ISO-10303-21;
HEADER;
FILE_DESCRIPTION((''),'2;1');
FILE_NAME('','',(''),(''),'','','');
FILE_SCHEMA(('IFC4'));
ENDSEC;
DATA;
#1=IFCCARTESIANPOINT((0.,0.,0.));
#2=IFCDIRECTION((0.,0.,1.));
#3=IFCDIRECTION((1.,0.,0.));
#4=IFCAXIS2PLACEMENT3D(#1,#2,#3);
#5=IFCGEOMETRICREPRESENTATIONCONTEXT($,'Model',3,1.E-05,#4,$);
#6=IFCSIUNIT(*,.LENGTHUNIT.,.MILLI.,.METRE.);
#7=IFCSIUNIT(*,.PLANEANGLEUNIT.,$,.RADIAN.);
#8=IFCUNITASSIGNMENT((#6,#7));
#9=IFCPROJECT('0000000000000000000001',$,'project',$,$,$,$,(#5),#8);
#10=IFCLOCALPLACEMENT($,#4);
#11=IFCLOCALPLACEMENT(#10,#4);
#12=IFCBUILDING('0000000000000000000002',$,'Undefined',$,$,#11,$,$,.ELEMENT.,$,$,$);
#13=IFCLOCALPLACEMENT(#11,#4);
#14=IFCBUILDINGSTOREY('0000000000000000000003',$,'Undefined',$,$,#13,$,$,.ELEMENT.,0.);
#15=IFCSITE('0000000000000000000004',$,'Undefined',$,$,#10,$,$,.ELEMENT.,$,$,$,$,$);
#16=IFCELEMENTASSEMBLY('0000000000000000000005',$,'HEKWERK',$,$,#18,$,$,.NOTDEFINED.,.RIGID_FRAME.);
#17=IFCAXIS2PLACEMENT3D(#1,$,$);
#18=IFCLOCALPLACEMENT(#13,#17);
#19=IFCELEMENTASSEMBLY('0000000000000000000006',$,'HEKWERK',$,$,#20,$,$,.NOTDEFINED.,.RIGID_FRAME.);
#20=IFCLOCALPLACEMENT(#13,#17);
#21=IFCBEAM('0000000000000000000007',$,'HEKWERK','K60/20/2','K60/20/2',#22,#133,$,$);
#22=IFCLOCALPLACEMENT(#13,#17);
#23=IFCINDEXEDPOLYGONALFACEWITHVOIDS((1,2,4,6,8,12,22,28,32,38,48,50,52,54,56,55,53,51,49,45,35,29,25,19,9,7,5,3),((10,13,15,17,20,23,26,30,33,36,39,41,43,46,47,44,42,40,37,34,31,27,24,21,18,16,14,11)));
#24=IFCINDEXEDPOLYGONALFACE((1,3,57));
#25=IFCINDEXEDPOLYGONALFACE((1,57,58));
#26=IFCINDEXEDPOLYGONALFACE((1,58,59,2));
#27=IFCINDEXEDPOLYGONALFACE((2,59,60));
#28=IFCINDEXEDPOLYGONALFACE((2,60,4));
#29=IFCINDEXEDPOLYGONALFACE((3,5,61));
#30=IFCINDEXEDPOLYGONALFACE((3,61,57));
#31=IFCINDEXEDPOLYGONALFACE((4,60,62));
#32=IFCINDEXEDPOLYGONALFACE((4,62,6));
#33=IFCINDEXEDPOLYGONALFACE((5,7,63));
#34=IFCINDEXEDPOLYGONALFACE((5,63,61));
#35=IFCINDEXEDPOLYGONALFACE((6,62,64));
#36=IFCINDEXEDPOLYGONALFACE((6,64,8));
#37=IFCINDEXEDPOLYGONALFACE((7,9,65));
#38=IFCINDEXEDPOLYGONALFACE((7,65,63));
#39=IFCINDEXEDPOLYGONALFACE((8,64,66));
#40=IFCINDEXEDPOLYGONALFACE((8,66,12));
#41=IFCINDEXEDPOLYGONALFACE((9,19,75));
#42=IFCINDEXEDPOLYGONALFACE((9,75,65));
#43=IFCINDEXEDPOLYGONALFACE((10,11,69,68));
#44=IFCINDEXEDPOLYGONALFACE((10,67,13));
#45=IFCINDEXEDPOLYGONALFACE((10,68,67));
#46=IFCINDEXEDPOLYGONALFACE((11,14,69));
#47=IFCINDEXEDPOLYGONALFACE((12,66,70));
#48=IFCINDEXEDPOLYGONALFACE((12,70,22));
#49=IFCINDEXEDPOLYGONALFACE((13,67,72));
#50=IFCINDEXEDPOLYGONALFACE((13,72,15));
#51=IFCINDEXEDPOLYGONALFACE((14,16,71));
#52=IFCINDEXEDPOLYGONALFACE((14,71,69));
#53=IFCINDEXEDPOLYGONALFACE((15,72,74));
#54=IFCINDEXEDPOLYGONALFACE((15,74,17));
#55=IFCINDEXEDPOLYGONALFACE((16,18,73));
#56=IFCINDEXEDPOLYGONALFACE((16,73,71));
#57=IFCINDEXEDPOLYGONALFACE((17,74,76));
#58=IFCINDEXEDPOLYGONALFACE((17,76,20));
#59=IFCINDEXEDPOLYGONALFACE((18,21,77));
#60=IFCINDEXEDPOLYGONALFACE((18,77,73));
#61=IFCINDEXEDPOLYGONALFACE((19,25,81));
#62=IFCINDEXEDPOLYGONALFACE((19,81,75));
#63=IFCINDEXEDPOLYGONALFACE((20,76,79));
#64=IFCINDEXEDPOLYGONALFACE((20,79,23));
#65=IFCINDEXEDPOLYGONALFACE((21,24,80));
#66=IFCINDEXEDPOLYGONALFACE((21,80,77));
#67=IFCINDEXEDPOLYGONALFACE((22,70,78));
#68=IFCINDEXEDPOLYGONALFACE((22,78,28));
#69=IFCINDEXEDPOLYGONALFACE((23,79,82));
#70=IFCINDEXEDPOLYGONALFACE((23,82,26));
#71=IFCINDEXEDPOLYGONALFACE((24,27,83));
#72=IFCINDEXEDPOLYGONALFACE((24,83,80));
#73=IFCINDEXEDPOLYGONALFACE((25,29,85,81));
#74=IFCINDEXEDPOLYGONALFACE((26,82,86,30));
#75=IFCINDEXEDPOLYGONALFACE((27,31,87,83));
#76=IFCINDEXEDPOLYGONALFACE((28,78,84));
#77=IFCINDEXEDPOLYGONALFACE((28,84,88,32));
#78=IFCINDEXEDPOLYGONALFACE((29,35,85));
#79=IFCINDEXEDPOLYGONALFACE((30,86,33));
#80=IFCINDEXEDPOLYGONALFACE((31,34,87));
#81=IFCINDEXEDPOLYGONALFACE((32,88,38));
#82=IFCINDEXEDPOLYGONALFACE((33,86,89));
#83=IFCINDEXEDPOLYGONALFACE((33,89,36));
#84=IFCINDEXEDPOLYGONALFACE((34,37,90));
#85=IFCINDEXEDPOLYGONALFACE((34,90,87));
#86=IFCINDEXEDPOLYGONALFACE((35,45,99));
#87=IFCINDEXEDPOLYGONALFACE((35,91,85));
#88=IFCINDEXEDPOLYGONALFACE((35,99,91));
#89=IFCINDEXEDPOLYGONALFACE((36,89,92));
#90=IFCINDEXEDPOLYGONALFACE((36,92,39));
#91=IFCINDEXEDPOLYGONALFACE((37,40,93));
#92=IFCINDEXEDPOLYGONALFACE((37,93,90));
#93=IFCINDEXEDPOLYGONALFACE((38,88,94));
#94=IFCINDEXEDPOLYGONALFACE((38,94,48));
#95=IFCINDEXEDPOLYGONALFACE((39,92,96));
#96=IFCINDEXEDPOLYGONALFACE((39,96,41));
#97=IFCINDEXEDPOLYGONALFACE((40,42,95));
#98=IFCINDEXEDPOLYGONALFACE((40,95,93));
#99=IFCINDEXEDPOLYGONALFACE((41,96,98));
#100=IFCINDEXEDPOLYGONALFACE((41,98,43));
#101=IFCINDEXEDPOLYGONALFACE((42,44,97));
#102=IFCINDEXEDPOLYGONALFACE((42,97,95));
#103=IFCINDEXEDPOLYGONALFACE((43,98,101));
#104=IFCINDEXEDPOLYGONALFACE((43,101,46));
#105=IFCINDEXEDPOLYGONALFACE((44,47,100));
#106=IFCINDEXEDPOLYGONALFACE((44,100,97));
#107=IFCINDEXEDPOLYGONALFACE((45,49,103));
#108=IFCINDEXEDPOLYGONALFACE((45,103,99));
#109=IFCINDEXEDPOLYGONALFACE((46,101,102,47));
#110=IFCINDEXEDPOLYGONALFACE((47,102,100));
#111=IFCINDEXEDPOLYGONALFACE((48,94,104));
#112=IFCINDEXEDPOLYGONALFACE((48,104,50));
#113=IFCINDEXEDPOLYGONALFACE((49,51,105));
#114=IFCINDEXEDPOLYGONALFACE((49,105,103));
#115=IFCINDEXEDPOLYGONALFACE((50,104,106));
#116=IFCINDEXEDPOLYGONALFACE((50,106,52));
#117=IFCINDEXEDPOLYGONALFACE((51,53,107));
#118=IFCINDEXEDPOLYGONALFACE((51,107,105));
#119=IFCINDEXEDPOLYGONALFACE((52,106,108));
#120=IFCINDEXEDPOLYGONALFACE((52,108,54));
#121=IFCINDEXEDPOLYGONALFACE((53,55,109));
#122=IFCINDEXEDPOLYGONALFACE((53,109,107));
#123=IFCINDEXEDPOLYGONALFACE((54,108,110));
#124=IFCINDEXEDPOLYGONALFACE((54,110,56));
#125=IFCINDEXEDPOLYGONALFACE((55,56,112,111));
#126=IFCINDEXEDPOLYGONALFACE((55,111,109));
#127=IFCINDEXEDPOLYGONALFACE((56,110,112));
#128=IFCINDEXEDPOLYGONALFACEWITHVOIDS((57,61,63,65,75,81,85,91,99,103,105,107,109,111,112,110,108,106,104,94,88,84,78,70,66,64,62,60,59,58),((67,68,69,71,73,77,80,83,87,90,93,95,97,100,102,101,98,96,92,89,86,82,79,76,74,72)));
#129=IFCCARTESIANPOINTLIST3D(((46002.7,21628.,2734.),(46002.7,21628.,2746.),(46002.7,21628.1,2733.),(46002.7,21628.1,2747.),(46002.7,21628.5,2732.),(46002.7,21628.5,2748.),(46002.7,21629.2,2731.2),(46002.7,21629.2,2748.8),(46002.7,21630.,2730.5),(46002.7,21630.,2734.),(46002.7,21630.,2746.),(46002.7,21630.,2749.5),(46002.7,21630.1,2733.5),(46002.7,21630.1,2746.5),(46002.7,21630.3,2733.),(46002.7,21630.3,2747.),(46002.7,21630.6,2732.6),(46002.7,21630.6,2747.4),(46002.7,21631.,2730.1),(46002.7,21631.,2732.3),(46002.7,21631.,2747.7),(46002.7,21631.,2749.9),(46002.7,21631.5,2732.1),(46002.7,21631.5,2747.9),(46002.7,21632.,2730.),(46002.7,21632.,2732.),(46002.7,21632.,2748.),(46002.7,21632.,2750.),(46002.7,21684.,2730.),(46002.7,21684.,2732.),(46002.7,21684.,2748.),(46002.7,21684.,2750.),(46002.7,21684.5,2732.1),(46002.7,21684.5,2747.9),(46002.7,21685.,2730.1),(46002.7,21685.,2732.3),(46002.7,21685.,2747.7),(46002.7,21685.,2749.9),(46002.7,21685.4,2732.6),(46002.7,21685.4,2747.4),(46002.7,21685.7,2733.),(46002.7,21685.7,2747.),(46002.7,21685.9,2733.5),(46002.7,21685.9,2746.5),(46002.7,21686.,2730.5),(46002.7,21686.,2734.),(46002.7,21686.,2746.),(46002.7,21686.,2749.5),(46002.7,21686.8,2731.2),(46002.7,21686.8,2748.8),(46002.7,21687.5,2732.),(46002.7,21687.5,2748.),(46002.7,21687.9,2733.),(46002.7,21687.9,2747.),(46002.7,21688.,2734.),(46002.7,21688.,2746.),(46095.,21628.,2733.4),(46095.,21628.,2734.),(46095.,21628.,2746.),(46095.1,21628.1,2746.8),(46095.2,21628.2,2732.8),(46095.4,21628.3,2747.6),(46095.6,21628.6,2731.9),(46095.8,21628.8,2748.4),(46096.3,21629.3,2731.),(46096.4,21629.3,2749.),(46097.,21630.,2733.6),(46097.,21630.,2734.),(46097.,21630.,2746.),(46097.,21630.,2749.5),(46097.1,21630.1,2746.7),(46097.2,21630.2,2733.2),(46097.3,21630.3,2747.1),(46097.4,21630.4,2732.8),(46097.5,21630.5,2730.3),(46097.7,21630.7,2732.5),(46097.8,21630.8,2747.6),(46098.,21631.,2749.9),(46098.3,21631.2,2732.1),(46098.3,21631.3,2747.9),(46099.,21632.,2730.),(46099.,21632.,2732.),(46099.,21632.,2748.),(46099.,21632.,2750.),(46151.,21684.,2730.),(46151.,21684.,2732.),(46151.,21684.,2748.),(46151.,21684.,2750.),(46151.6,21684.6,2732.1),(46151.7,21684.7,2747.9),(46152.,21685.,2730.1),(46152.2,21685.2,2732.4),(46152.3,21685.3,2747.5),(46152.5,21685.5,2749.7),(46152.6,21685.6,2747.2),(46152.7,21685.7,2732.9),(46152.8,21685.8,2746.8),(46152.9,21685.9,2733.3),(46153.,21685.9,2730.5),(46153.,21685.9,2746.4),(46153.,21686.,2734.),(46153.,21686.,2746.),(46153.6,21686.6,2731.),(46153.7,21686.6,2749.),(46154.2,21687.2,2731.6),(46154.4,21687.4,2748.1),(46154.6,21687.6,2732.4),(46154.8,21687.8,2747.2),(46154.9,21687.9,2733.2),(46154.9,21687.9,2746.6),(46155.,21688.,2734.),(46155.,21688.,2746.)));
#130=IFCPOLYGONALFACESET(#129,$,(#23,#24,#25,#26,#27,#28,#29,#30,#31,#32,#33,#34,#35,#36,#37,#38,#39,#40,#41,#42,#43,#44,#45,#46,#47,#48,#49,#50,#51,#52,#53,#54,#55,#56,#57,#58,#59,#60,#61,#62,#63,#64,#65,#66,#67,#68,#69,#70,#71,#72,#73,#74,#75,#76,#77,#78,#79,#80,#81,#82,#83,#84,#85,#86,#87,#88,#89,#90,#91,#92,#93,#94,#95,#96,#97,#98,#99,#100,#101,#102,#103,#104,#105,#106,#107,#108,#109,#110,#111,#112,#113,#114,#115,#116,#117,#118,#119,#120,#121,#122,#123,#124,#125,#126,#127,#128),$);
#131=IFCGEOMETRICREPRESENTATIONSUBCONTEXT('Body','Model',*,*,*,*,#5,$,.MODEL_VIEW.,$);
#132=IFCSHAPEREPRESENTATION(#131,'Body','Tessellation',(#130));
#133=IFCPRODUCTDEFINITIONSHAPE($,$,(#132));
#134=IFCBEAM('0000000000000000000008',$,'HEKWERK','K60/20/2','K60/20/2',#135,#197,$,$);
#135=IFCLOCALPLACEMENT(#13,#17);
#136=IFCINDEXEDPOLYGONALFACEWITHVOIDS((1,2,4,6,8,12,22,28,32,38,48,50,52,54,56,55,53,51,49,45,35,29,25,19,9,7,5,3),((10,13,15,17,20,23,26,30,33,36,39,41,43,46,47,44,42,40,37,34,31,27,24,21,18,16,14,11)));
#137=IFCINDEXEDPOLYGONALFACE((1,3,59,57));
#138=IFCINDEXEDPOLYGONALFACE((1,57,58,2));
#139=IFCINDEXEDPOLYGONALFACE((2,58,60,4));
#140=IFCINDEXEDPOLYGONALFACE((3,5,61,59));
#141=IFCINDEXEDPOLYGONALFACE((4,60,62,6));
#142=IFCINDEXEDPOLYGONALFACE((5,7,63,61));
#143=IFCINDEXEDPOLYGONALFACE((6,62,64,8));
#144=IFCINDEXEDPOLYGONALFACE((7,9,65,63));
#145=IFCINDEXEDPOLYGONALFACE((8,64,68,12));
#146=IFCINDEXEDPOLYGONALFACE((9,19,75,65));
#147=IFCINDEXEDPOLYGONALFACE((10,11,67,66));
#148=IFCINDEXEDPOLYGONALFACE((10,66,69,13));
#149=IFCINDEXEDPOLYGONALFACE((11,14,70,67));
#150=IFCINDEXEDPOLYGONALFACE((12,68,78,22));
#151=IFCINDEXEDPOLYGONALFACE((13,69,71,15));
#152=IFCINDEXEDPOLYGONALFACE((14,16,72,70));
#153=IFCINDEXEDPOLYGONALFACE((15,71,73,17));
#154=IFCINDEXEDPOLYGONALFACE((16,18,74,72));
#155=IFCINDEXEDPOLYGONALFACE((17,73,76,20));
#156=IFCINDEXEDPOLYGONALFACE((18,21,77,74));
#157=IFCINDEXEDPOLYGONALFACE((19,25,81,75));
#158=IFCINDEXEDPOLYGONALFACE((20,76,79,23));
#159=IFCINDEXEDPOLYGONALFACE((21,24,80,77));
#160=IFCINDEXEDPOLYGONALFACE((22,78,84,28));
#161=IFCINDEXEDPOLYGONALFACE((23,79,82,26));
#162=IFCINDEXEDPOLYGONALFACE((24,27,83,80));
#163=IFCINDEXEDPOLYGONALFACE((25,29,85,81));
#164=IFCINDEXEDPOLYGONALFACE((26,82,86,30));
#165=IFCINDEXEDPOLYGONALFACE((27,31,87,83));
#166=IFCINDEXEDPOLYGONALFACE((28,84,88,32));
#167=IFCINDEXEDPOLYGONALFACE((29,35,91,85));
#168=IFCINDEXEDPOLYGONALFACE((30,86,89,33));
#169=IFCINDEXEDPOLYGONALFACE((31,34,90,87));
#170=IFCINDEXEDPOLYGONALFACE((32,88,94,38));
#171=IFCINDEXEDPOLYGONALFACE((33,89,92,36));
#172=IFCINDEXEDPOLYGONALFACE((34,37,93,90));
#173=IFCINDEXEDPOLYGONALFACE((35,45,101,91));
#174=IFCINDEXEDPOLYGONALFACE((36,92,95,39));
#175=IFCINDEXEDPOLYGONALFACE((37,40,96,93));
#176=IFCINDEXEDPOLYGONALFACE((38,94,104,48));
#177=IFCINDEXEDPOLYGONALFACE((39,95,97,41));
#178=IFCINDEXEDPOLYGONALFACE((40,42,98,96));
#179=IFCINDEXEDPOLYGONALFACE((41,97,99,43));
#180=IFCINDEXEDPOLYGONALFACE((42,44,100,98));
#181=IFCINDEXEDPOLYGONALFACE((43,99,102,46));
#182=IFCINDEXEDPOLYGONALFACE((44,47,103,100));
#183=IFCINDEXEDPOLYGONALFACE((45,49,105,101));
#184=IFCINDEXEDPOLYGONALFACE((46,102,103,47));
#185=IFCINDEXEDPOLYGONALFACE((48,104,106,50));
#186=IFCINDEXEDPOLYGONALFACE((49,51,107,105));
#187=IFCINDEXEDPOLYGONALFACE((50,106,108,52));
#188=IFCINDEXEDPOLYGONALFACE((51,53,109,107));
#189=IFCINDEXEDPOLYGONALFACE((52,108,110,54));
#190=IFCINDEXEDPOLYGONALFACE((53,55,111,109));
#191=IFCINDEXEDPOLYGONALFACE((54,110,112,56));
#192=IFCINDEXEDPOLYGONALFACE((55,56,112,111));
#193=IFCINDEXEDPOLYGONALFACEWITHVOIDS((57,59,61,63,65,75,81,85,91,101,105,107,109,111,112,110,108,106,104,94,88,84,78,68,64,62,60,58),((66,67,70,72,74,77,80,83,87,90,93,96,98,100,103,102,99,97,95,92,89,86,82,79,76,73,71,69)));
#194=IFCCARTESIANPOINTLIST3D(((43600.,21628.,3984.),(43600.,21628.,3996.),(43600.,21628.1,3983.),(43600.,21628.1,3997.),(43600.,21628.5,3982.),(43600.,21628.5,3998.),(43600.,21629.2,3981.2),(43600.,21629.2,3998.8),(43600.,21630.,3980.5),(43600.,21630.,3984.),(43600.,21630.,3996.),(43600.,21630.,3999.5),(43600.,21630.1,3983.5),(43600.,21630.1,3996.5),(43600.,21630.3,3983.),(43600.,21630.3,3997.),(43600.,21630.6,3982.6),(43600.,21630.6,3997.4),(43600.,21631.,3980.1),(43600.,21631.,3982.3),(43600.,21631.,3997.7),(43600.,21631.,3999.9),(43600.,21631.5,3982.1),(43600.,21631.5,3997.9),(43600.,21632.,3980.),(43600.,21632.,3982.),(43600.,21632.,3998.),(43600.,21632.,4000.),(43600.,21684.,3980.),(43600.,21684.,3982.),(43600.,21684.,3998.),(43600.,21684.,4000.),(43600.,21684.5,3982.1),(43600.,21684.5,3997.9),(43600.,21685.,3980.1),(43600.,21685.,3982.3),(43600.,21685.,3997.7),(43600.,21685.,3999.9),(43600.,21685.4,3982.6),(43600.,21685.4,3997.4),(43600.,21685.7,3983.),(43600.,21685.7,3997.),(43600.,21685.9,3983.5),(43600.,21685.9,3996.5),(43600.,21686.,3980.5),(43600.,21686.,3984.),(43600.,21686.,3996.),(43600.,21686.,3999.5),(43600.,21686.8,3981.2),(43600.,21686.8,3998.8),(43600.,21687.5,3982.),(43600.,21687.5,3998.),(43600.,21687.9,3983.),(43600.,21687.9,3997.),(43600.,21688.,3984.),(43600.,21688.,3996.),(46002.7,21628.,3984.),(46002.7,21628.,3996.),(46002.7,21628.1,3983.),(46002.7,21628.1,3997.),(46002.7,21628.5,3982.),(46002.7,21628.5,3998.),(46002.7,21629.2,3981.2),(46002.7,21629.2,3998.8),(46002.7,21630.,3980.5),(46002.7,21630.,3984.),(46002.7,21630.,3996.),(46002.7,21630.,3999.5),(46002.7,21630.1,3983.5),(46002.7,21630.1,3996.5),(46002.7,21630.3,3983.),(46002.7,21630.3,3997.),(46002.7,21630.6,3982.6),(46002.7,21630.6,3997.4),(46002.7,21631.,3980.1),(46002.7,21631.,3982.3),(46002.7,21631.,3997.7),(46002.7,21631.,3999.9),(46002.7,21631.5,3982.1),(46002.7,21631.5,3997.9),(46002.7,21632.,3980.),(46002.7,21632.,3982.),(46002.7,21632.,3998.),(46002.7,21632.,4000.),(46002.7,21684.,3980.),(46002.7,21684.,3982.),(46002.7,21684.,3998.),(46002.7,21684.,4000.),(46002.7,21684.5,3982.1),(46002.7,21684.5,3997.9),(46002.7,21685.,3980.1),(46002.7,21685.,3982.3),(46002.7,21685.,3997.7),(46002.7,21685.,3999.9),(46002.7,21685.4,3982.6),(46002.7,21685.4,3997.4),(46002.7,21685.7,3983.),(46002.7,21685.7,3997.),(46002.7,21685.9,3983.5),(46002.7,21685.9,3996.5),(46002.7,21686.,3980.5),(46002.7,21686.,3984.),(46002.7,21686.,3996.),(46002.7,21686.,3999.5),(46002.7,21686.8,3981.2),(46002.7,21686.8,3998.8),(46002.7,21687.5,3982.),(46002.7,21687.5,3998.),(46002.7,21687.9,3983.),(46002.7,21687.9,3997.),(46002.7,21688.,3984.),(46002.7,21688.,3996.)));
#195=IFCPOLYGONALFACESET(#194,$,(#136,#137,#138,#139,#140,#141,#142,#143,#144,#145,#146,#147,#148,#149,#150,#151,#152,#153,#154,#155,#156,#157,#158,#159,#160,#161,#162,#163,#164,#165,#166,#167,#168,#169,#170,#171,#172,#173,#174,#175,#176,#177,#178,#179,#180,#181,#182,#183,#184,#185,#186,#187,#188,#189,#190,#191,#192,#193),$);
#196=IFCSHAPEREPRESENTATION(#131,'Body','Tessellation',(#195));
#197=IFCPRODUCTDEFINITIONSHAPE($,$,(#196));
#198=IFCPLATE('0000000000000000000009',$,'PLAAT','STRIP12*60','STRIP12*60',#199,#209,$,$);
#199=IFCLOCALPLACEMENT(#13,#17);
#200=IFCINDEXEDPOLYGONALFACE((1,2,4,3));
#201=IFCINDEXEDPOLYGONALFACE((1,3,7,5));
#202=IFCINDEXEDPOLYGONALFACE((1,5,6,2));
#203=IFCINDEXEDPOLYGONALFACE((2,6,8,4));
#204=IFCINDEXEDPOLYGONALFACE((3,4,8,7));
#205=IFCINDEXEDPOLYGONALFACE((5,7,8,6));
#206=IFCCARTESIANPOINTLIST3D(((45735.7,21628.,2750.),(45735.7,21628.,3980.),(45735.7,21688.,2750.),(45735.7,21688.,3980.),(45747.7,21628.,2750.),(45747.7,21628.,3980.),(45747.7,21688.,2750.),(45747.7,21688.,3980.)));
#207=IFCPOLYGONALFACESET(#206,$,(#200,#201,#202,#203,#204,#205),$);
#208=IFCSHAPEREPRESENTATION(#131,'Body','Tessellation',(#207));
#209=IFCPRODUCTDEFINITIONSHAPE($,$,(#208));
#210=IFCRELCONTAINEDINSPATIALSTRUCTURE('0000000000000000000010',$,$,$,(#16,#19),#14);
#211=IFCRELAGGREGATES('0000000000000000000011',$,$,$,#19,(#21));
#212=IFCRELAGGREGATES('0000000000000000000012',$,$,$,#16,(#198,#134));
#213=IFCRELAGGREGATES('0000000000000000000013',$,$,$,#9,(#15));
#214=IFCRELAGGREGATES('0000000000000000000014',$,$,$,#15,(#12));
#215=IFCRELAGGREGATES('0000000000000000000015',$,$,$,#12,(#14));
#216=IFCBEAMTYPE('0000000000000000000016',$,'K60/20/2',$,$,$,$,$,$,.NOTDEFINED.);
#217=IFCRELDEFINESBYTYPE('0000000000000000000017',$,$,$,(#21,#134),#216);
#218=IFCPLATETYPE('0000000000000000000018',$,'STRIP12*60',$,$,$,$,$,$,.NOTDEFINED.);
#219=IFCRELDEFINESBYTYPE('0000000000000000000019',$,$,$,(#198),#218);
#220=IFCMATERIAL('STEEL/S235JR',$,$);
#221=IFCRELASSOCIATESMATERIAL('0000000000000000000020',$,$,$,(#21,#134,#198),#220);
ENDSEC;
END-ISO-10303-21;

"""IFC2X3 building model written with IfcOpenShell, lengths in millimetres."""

from ifc_helpers import new_model, si_unit, frame, origin_with_axes, origin_2d_with_axis, place, context, subcontext, project, spatial, rectangle, hollow_rectangle, extrude, clip, halfspace, material, type_object, element, aggregate, save


model = new_model("IFC2X3")

# Units and contexts
model_context = context("Model", 3, precision=1e-05, world=origin_with_axes())
body_context = subcontext(model_context, "Body", "Model", "MODEL_VIEW")
ifc_project = project(units=[si_unit("LENGTHUNIT", "METRE", prefix="MILLI"), si_unit("PLANEANGLEUNIT", "RADIAN")], contexts=[model_context])

# Site, building, storey
site_placement = place(None, origin_with_axes())
site = spatial("IfcSite", under=ifc_project, at=site_placement, Name="Undefined", CompositionType="ELEMENT")
building_placement = place(site_placement, origin_with_axes())
building = spatial("IfcBuilding", under=site, at=building_placement, Name="Undefined", CompositionType="ELEMENT")
storey_placement = place(building_placement, origin_with_axes())
storey = spatial("IfcBuildingStorey", under=building, at=storey_placement, Name="Undefined", CompositionType="ELEMENT", Elevation=0.0)

# Element assembly
assembly_1_placement = place(storey_placement, origin_with_axes())
assembly_1 = element("IfcElementAssembly", 1, at=assembly_1_placement, inside=storey, Name="HEKWERK", AssemblyPlace="NOTDEFINED", PredefinedType="RIGID_FRAME")
ifc_material_1 = material(Name="STEEL/S235JR")
beam_type_1 = type_object("IfcBeamType", Name="K60/20/2", PredefinedType="NOTDEFINED")

# Element assembly, beam
assembly_2_placement = place(storey_placement, origin_with_axes())
assembly_2 = element("IfcElementAssembly", 2, at=assembly_2_placement, inside=storey, Name="HEKWERK", AssemblyPlace="NOTDEFINED", PredefinedType="RIGID_FRAME")
beam_1_placement = place(assembly_2_placement, frame((46098.4, 21658.0, 2740.0), z_axis=(0.0, -1.0, 0.0), x_axis=(-1.0, 0.0, 0.0)))
beam_1 = element("IfcBeam", 3, at=beam_1_placement, type_object=beam_type_1, material=ifc_material_1, Name="HEKWERK", Description="K60/20/2", ObjectType="K60/20/2", context=body_context, shape_type="Clipping", body=[
    clip(extrude(hollow_rectangle(XDim=20.0, YDim=60.0, WallThickness=2.0, InnerFilletRadius=2.0, OuterFilletRadius=4.0, at=origin_2d_with_axis()), frame((95.8, 0.0, 0.0), z_axis=(-1.0, 0.0, 0.0), x_axis=(0.0, -1.0, 0.0)), (0.0, 0.0, 1.0), 152.6), halfspace(frame((-56.6, 0.0, -30.0), z_axis=(0.707107, 0.0, -0.707107), x_axis=(0.0, -1.0, 0.0)), True)),
])

# Beam
beam_2_placement = place(assembly_1_placement, frame((46002.7, 21658.0, 3990.0), z_axis=(0.0, -1.0, 0.0), x_axis=(-1.0, 0.0, 0.0)))
beam_2 = element("IfcBeam", 4, at=beam_2_placement, type_object=beam_type_1, material=ifc_material_1, Name="HEKWERK", Description="K60/20/2", ObjectType="K60/20/2", context=body_context, shape_type="SweptSolid", body=[
    extrude(hollow_rectangle(XDim=20.0, YDim=60.0, WallThickness=2.0, InnerFilletRadius=2.0, OuterFilletRadius=4.0, at=origin_2d_with_axis()), frame((2402.7, 0.0, 0.0), z_axis=(-1.0, 0.0, 0.0), x_axis=(0.0, -1.0, 0.0)), (0.0, 0.0, 1.0), 2402.7),
])

# Plate
plate_type = type_object("IfcPlateType", Name="STRIP12*60", PredefinedType="NOTDEFINED")
plate_placement = place(assembly_1_placement, frame((45741.7, 21658.0, 3980.0), z_axis=(0.0, -1.0, 0.0), x_axis=(0.0, 0.0, -1.0)))
plate = element("IfcPlate", 5, at=plate_placement, type_object=plate_type, material=ifc_material_1, Name="PLAAT", Description="STRIP12*60", ObjectType="STRIP12*60", context=body_context, shape_type="SweptSolid", body=[
    extrude(rectangle(XDim=12.0, YDim=60.0, at=origin_2d_with_axis()), frame((1230.0, 0.0, 0.0), z_axis=(-1.0, 0.0, 0.0), x_axis=(0.0, -1.0, 0.0)), (0.0, 0.0, 1.0), 1230.0),
])

aggregate(assembly_2, [beam_1])
aggregate(assembly_1, [plate, beam_2])

save(model, "model.ifc")
